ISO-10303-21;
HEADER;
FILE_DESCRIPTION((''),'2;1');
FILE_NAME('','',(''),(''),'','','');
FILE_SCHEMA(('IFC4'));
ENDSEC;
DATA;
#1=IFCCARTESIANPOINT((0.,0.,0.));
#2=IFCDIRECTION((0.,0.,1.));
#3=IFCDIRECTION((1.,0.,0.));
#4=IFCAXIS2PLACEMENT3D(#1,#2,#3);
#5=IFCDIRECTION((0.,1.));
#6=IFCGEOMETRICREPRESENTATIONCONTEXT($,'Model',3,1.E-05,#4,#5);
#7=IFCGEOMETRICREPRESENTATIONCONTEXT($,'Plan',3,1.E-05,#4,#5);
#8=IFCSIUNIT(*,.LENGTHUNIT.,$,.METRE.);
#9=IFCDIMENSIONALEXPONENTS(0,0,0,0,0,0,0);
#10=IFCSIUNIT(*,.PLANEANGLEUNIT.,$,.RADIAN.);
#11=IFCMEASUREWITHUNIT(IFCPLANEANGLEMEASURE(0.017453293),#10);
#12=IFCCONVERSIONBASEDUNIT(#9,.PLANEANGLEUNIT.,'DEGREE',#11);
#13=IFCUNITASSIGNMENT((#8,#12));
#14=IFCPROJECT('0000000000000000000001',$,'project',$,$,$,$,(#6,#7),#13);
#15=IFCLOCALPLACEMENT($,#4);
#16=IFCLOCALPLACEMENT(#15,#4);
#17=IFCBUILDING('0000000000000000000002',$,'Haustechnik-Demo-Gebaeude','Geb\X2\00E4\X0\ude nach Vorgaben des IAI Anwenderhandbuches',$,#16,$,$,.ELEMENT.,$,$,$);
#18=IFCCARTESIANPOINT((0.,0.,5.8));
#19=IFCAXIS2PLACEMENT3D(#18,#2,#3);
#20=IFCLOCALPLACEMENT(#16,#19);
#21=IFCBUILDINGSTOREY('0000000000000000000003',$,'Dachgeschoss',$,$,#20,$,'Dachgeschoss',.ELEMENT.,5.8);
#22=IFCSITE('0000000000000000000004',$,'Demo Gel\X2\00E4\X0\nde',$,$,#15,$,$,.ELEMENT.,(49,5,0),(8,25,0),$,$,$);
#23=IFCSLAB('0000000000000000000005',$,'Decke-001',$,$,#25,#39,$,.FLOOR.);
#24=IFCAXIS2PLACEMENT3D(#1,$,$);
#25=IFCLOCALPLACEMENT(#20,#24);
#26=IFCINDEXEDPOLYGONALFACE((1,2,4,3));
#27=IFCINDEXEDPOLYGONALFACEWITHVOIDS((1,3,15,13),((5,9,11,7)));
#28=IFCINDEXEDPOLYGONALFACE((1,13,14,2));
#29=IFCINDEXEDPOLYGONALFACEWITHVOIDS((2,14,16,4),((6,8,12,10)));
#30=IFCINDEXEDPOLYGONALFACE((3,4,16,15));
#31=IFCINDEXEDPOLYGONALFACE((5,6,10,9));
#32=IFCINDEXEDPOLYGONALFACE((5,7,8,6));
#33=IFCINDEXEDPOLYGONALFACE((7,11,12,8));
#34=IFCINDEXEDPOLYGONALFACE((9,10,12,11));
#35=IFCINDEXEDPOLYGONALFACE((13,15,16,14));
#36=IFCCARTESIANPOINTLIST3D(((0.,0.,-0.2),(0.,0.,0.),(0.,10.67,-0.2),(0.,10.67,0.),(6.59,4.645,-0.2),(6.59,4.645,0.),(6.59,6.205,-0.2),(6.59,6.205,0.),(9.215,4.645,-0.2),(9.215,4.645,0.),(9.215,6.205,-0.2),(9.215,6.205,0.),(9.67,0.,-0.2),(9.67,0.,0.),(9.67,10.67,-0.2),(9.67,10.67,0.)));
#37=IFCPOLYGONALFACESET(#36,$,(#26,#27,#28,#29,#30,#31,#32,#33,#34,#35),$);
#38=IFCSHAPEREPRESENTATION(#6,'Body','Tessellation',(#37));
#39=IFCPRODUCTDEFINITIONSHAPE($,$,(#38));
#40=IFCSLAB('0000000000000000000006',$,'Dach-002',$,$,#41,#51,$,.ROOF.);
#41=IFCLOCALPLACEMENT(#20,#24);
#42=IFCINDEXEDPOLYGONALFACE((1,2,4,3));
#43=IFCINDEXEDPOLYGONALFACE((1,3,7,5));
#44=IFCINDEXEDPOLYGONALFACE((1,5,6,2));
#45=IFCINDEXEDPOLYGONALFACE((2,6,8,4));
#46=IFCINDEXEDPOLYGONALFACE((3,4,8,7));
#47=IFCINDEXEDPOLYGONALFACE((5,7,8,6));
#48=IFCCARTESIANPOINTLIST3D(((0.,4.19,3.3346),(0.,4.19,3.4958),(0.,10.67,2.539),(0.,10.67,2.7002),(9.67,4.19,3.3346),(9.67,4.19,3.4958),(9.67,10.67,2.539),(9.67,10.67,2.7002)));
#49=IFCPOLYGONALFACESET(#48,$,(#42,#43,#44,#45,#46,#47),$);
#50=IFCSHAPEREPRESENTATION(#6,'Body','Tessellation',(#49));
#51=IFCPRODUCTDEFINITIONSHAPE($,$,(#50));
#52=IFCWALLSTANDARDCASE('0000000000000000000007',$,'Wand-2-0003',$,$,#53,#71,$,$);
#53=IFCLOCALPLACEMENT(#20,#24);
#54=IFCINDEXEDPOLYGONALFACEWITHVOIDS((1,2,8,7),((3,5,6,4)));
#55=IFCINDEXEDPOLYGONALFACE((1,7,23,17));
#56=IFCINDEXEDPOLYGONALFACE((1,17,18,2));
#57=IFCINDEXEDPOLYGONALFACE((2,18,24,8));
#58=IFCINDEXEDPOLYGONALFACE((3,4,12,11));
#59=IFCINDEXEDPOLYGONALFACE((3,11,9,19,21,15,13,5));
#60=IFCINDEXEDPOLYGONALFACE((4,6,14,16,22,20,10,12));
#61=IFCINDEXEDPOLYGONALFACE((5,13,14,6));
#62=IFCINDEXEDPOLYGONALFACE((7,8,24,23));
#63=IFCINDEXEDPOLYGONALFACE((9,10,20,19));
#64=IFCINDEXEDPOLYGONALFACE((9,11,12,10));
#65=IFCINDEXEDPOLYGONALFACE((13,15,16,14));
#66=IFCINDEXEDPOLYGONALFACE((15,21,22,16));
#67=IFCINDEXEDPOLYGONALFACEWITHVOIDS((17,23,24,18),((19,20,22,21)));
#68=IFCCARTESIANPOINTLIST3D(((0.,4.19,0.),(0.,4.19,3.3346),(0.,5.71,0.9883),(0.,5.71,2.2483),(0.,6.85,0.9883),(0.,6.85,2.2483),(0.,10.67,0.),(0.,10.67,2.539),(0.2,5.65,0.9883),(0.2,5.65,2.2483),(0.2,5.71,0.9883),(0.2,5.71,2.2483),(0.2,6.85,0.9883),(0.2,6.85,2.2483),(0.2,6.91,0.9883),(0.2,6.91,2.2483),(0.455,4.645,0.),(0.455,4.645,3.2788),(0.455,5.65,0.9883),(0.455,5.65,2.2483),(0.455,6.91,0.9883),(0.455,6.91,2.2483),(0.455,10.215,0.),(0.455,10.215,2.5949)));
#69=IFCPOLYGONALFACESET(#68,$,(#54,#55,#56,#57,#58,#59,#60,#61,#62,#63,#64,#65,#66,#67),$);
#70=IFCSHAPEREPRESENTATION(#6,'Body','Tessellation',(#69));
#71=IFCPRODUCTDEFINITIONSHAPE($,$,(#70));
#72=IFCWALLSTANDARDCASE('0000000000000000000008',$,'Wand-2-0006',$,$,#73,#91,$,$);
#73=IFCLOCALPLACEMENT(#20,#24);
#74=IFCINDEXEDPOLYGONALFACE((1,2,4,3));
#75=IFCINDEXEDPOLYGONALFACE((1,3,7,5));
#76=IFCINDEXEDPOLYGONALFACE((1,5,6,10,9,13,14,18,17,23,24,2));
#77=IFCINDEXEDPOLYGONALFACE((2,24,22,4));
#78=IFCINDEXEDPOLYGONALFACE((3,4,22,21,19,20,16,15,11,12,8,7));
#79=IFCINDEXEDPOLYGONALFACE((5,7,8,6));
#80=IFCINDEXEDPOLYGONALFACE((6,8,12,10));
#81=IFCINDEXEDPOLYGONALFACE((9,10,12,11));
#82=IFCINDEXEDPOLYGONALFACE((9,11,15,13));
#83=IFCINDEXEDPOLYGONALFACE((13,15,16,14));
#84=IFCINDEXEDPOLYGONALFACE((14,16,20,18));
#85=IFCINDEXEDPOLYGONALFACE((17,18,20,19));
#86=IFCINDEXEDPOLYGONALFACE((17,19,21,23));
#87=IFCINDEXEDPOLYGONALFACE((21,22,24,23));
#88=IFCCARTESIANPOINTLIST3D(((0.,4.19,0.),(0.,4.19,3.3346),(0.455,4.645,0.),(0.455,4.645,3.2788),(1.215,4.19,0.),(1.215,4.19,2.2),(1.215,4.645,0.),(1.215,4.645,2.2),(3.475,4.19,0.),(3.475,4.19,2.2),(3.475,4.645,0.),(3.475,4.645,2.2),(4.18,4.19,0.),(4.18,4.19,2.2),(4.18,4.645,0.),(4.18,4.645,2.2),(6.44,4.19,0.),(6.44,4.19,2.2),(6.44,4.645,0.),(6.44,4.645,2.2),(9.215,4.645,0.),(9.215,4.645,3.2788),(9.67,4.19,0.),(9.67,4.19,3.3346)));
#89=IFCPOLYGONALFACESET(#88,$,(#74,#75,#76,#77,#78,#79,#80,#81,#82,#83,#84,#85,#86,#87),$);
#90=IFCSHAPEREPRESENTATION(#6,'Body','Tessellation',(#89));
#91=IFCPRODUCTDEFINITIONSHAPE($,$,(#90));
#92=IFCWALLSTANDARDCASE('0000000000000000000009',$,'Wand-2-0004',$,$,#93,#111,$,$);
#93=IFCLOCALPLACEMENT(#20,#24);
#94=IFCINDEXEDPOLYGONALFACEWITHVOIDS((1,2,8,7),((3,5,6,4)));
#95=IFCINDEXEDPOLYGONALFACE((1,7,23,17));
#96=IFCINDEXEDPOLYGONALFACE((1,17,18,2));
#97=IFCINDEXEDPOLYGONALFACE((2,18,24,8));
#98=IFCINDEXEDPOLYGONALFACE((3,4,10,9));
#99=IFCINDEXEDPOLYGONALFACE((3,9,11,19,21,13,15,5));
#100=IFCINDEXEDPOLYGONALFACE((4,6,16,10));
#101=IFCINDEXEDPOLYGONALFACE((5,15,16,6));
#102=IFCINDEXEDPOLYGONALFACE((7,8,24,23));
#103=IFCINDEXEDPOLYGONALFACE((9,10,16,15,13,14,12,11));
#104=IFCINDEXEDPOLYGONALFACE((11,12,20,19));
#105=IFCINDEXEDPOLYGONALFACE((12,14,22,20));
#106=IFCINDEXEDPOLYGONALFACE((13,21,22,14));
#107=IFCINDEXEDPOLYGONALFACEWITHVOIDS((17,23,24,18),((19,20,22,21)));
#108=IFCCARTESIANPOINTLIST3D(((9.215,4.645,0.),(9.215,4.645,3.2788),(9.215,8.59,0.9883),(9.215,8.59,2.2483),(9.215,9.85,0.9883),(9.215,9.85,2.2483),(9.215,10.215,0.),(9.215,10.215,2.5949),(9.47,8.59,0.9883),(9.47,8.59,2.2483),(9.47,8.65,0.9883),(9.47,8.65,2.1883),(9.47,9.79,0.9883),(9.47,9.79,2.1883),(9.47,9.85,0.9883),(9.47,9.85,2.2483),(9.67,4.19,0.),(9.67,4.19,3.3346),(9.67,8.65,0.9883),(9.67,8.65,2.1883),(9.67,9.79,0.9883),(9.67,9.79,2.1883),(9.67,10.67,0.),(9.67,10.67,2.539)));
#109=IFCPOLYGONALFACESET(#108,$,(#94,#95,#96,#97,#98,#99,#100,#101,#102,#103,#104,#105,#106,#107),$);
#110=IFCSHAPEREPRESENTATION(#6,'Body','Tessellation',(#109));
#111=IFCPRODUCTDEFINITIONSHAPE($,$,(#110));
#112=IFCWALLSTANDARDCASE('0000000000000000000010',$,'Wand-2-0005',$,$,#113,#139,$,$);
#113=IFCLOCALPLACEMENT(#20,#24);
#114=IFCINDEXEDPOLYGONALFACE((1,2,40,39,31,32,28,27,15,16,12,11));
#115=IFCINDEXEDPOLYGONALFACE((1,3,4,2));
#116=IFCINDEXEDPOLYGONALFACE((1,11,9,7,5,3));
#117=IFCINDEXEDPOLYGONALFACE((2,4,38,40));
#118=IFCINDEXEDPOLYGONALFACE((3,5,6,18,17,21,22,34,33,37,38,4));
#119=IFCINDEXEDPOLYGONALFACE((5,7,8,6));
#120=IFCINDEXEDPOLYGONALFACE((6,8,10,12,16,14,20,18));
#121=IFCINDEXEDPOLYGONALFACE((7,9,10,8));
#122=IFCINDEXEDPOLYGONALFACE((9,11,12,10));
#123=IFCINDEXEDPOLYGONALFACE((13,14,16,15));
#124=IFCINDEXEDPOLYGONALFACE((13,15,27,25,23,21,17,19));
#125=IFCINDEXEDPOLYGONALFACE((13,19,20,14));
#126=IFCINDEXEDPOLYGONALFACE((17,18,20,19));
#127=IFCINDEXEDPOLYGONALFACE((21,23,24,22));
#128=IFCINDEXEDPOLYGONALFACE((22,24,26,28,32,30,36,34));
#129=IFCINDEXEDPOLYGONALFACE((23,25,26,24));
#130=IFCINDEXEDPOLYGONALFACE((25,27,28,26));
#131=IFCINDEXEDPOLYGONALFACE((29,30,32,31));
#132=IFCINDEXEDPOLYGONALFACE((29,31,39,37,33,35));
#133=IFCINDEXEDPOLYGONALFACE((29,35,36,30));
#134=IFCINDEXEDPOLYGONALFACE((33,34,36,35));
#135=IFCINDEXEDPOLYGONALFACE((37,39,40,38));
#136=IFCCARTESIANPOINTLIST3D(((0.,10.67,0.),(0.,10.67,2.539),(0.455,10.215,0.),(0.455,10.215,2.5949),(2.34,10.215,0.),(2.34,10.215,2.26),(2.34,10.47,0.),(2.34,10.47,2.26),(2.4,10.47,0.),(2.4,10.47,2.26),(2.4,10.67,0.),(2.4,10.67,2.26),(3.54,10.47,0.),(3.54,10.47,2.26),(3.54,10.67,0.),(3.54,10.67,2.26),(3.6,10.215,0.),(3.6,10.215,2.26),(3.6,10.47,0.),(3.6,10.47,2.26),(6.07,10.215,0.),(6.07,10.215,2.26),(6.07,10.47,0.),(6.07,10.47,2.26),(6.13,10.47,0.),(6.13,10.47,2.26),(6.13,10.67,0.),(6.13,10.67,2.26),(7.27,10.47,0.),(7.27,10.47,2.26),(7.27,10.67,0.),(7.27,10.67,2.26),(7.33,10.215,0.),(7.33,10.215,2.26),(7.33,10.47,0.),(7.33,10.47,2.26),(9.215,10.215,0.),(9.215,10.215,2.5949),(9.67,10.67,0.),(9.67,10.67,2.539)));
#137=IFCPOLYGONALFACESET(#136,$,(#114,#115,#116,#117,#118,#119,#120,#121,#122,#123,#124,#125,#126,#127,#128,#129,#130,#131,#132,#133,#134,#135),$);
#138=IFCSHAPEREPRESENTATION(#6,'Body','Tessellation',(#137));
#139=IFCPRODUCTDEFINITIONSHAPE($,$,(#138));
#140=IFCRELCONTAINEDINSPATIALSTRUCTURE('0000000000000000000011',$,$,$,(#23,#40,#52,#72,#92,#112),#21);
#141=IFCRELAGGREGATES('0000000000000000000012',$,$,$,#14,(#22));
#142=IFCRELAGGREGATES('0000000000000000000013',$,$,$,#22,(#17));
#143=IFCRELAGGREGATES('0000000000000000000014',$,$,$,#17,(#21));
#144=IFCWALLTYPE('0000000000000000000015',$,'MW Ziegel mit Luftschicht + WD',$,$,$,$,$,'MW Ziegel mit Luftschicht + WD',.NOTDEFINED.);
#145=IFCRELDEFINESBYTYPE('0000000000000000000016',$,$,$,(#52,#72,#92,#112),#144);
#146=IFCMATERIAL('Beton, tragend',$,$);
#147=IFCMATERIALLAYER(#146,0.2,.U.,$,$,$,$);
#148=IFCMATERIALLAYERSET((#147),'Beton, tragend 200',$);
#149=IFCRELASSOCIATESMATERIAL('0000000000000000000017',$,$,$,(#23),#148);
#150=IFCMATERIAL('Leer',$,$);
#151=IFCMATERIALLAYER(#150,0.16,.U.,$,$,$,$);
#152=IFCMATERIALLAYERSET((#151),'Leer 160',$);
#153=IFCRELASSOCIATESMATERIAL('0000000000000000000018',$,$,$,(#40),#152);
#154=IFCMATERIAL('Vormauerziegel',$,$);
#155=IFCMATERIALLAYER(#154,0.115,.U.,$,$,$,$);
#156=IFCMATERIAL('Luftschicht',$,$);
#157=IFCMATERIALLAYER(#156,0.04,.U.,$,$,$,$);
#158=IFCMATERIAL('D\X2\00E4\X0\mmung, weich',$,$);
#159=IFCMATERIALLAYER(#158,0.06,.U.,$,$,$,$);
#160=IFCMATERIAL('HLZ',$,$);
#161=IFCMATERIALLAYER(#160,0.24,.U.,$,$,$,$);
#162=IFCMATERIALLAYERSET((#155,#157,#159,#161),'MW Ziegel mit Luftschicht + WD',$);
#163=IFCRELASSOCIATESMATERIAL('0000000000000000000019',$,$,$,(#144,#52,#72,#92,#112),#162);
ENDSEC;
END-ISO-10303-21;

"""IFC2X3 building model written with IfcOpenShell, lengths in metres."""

from ifc_helpers import new_model, entity, si_unit, converted_unit, direction, frame, frame_2d, origin_with_axes, place, context, project, spatial, polyline, rectangle, outline, extrude, clip, halfspace, bounded_halfspace, material, layer, layer_set, layer_usage, type_object, element, save


model = new_model("IFC2X3")

# Units and contexts
model_context = context("Model", 3, precision=1e-05, world=origin_with_axes(), true_north=direction((0.0, 1.0)))
plan_context = context("Plan", 3, precision=1e-05, world=origin_with_axes(), true_north=direction((0.0, 1.0)))
ifc_project = project(units=[si_unit("LENGTHUNIT", "METRE"), converted_unit("PLANEANGLEUNIT", "DEGREE", entity("IfcPlaneAngleMeasure", 0.017453293), si_unit("PLANEANGLEUNIT", "RADIAN"), dimensions=[0, 0, 0, 0, 0, 0, 0])], contexts=[model_context, plan_context])

# Site, building, storey
site_placement = place(None, origin_with_axes())
site = spatial("IfcSite", under=ifc_project, at=site_placement, Name="Demo Gelände", CompositionType="ELEMENT", RefLatitude=(49, 5, 0), RefLongitude=(8, 25, 0))
building_placement = place(site_placement, origin_with_axes())
building = spatial("IfcBuilding", under=site, at=building_placement, Name="Haustechnik-Demo-Gebaeude", Description="Gebäude nach Vorgaben des IAI Anwenderhandbuches", CompositionType="ELEMENT")
storey_placement = place(building_placement, frame((0.0, 0.0, 5.8), z_axis=(0.0, 0.0, 1.0), x_axis=(1.0, 0.0, 0.0)))
storey = spatial("IfcBuildingStorey", under=building, at=storey_placement, Name="Dachgeschoss", LongName="Dachgeschoss", CompositionType="ELEMENT", Elevation=5.8)

# Slab, opening
ifc_material_1 = material(Name="Beton, tragend")
ifc_layer_1 = layer(ifc_material_1, 0.2, ventilated="UNKNOWN")
ifc_layer_set_1 = layer_set([ifc_layer_1], Name="Beton, tragend 200")
ifc_layer_usage_1 = layer_usage(ifc_layer_set_1, "AXIS3", "NEGATIVE", 0.2)
slab_1_placement = place(storey_placement, frame((9.67, 10.67, -0.2), z_axis=(0.0, 0.0, 1.0), x_axis=(-1.0, 0.0, 0.0)))
slab_1 = element("IfcSlab", 1, at=slab_1_placement, inside=storey, material=ifc_layer_usage_1, Name="Decke-001", PredefinedType="FLOOR", context=model_context, shape_type="SweptSolid", body=[
    extrude(outline(polyline([(0.0, 0.0), (9.67, 0.0), (9.67, 6.48), (9.67, 10.67), (0.0, 10.67), (0.0, 6.48), (0.0, 0.0)])), origin_with_axes(), (0.0, 0.0, 1.0), 0.2),
])
opening_1_placement = place(slab_1_placement, origin_with_axes())
element("IfcOpeningElement", 2, at=opening_1_placement, cuts=slab_1, context=model_context, shape_type="SweptSolid", body=[
    extrude(outline(polyline([(0.455, 6.025), (3.08, 6.025), (3.08, 4.465), (0.455, 4.465), (0.455, 6.025)])), origin_with_axes(), (0.0, 0.0, 1.0), 0.2),
])

# Slab
ifc_material_2 = material(Name="Leer")
ifc_layer_2 = layer(ifc_material_2, 0.16, ventilated="UNKNOWN")
ifc_layer_set_2 = layer_set([ifc_layer_2], Name="Leer 160")
ifc_layer_usage_2 = layer_usage(ifc_layer_set_2, "AXIS3", "NEGATIVE", 0.16)
slab_2_placement = place(storey_placement, frame((9.67, 10.67, 2.539), z_axis=(0.0, 0.121869, 0.992546), x_axis=(-1.0, 0.0, 0.0)))
element("IfcSlab", 3, at=slab_2_placement, inside=storey, material=ifc_layer_usage_2, Name="Dach-002", PredefinedType="ROOF", context=model_context, shape_type="SweptSolid", body=[
    extrude(outline(polyline([(9.67, 0.0), (9.67, 6.5287), (0.0, 6.5287), (0.0, 0.0), (9.67, 0.0)])), origin_with_axes(), (0.0, 0.121869, 0.992546), 0.1612),
])

# Wall, opening
ifc_material_3 = material(Name="Vormauerziegel")
ifc_layer_3 = layer(ifc_material_3, 0.115, ventilated="UNKNOWN")
ifc_material_4 = material(Name="Luftschicht")
ifc_layer_4 = layer(ifc_material_4, 0.04, ventilated="UNKNOWN")
ifc_material_5 = material(Name="Dämmung, weich")
ifc_layer_5 = layer(ifc_material_5, 0.06, ventilated="UNKNOWN")
ifc_material_6 = material(Name="HLZ")
ifc_layer_6 = layer(ifc_material_6, 0.24, ventilated="UNKNOWN")
ifc_layer_set_3 = layer_set([ifc_layer_3, ifc_layer_4, ifc_layer_5, ifc_layer_6], Name="MW Ziegel mit Luftschicht + WD")
ifc_layer_usage_3 = layer_usage(ifc_layer_set_3, "AXIS2", "POSITIVE", 0.0)
wall_type_1 = type_object("IfcWallType", Name="MW Ziegel mit Luftschicht + WD", ElementType="MW Ziegel mit Luftschicht + WD", PredefinedType="NOTDEFINED", material=ifc_layer_set_3)
wall_1_placement = place(storey_placement, frame((0.0, 10.67, 0.0), z_axis=(0.0, 0.0, 1.0), x_axis=(0.0, -1.0, 0.0)))
wall_1 = element("IfcWallStandardCase", 4, at=wall_1_placement, inside=storey, type_object=wall_type_1, material=ifc_layer_usage_3, Name="Wand-2-0003", context=model_context, shape_type="Clipping", body=[
    clip(clip(extrude(outline(polyline([(0.0, 0.0), (6.48, 0.0), (6.025, 0.455), (0.455, 0.455), (0.0, 0.0)])), origin_with_axes(), (0.0, 0.0, 1.0), 4.0), halfspace(frame((-0.3071, 0.0, 2.5013), z_axis=(-0.121869, 0.0, 0.992546), x_axis=(0.0, 1.0, 0.0)), False)), halfspace(frame((-0.3266, 0.0, 2.6596), z_axis=(-0.121869, 0.0, 0.992546), x_axis=(0.0, 1.0, 0.0)), False)),
])
opening_2_placement = place(wall_1_placement, frame((4.39, 0.0, 0.9883), z_axis=(0.0, 0.0, 1.0), x_axis=(1.0, 0.0, 0.0)))
element("IfcOpeningElement", 5, at=opening_2_placement, cuts=wall_1, ObjectType="Opening", context=model_context, shape_type="SweptSolid", body=[
    extrude(outline(polyline([(-0.57, 0.0), (0.57, 0.0), (0.57, 0.2), (0.63, 0.2), (0.63, 0.455), (-0.63, 0.455), (-0.63, 0.2), (-0.57, 0.2), (-0.57, 0.0)])), origin_with_axes(), (0.0, 0.0, 1.0), 1.26),
])

# Wall, openings
ifc_layer_usage_4 = layer_usage(ifc_layer_set_3, "AXIS2", "POSITIVE", 0.0)
wall_2_placement = place(storey_placement, frame((0.0, 4.19, 0.0), z_axis=(0.0, 0.0, 1.0), x_axis=(1.0, 0.0, 0.0)))
wall_2 = element("IfcWallStandardCase", 6, at=wall_2_placement, inside=storey, type_object=wall_type_1, material=ifc_layer_usage_4, Name="Wand-2-0006", context=model_context, shape_type="Clipping", body=[
    clip(clip(extrude(outline(polyline([(0.0, 0.0), (9.67, 0.0), (9.215, 0.455), (0.455, 0.455), (0.0, 0.0)])), origin_with_axes(), (0.0, 0.0, 1.0), 4.0), halfspace(frame((0.0, 0.4034, 3.2851), z_axis=(0.0, 0.121869, 0.992546), x_axis=(0.0, 0.992546, -0.121869)), False)), bounded_halfspace(frame((0.0, 0.4228, 3.4434), z_axis=(0.0, 0.121869, 0.992546), x_axis=(0.0, 0.992546, -0.121869)), False, origin_with_axes(), polyline([(9.67, -0.2275), (9.67, 0.6825), (0.0, 0.6825), (0.0, -0.2275), (9.67, -0.2275)]))),
])
opening_3_placement = place(wall_2_placement, frame((2.345, 0.0, 0.0), z_axis=(0.0, 0.0, 1.0), x_axis=(1.0, 0.0, 0.0)))
element("IfcOpeningElement", 7, at=opening_3_placement, cuts=wall_2, ObjectType="Opening", context=model_context, shape_type="SweptSolid", body=[
    extrude(rectangle(XDim=2.26, YDim=2.2, at=frame_2d((0.0, 1.1), x_axis=(-1.0, 0.0))), frame((0.0, 0.0, 0.0), z_axis=(0.0, 1.0, 0.0), x_axis=(-1.0, 0.0, 0.0)), (0.0, 0.0, 1.0), 0.455),
])
opening_4_placement = place(wall_2_placement, frame((5.31, 0.0, 0.0), z_axis=(0.0, 0.0, 1.0), x_axis=(1.0, 0.0, 0.0)))
element("IfcOpeningElement", 8, at=opening_4_placement, cuts=wall_2, ObjectType="Opening", context=model_context, shape_type="SweptSolid", body=[
    extrude(rectangle(XDim=2.26, YDim=2.2, at=frame_2d((0.0, 1.1), x_axis=(1.0, 0.0))), frame((0.0, 0.0, 0.0), z_axis=(0.0, 1.0, 0.0), x_axis=(-1.0, 0.0, 0.0)), (0.0, 0.0, 1.0), 0.455),
])

# Wall, opening
ifc_layer_usage_5 = layer_usage(ifc_layer_set_3, "AXIS2", "POSITIVE", 0.0)
wall_3_placement = place(storey_placement, frame((9.67, 4.19, 0.0), z_axis=(0.0, 0.0, 1.0), x_axis=(0.0, 1.0, 0.0)))
wall_3 = element("IfcWallStandardCase", 9, at=wall_3_placement, inside=storey, type_object=wall_type_1, material=ifc_layer_usage_5, Name="Wand-2-0004", context=model_context, shape_type="Clipping", body=[
    clip(clip(extrude(outline(polyline([(0.0, 0.0), (6.48, 0.0), (6.025, 0.455), (0.455, 0.455), (0.0, 0.0)])), origin_with_axes(), (0.0, 0.0, 1.0), 4.0), halfspace(frame((0.4034, 0.0, 3.2851), z_axis=(0.121869, 0.0, 0.992546), x_axis=(0.0, 1.0, 0.0)), False)), halfspace(frame((0.4228, 0.0, 3.4434), z_axis=(0.121869, 0.0, 0.992546), x_axis=(0.0, 1.0, 0.0)), False)),
])
opening_5_placement = place(wall_3_placement, frame((5.03, 0.0, 0.9883), z_axis=(0.0, 0.0, 1.0), x_axis=(1.0, 0.0, 0.0)))
element("IfcOpeningElement", 10, at=opening_5_placement, cuts=wall_3, ObjectType="Opening", context=model_context, shape_type="SweptSolid", body=[
    extrude(rectangle(XDim=1.26, YDim=1.26, at=frame_2d((0.0, 0.63), x_axis=(1.0, 0.0))), frame((0.0, 0.2, 0.0), z_axis=(0.0, 1.0, 0.0), x_axis=(-1.0, 0.0, 0.0)), (0.0, 0.0, 1.0), 0.255),
    extrude(rectangle(XDim=1.14, YDim=1.2, at=frame_2d((0.0, 0.6), x_axis=(1.0, 0.0))), frame((0.0, 0.0, 0.0), z_axis=(0.0, 1.0, 0.0), x_axis=(-1.0, 0.0, 0.0)), (0.0, 0.0, 1.0), 0.2),
])

# Wall, openings
ifc_layer_usage_6 = layer_usage(ifc_layer_set_3, "AXIS2", "NEGATIVE", 0.0)
wall_4_placement = place(storey_placement, frame((0.0, 10.67, 0.0), z_axis=(0.0, 0.0, 1.0), x_axis=(1.0, 0.0, 0.0)))
wall_4 = element("IfcWallStandardCase", 11, at=wall_4_placement, inside=storey, type_object=wall_type_1, material=ifc_layer_usage_6, Name="Wand-2-0005", context=model_context, shape_type="Clipping", body=[
    clip(clip(extrude(outline(polyline([(0.455, -0.455), (9.215, -0.455), (9.67, 0.0), (0.0, 0.0), (0.455, -0.455)])), origin_with_axes(), (0.0, 0.0, 1.0), 4.0), halfspace(frame((0.0, 0.3071, 2.5013), z_axis=(0.0, 0.121869, 0.992546), x_axis=(0.0, 0.992546, -0.121869)), False)), halfspace(frame((0.0, 0.3266, 2.6596), z_axis=(0.0, 0.121869, 0.992546), x_axis=(0.0, 0.992546, -0.121869)), False)),
])
opening_6_placement = place(wall_4_placement, frame((2.97, -0.455, 0.0), z_axis=(0.0, 0.0, 1.0), x_axis=(1.0, 0.0, 0.0)))
element("IfcOpeningElement", 12, at=opening_6_placement, cuts=wall_4, ObjectType="Opening", context=model_context, shape_type="SweptSolid", body=[
    extrude(outline(polyline([(-0.63, 0.0), (0.63, 0.0), (0.63, 0.255), (0.57, 0.255), (0.57, 0.455), (-0.57, 0.455), (-0.57, 0.255), (-0.63, 0.255), (-0.63, 0.0)])), origin_with_axes(), (0.0, 0.0, 1.0), 2.26),
])
opening_7_placement = place(wall_4_placement, frame((6.7, -0.455, 0.0), z_axis=(0.0, 0.0, 1.0), x_axis=(1.0, 0.0, 0.0)))
element("IfcOpeningElement", 13, at=opening_7_placement, cuts=wall_4, ObjectType="Opening", context=model_context, shape_type="SweptSolid", body=[
    extrude(outline(polyline([(-0.63, 0.0), (0.63, 0.0), (0.63, 0.255), (0.57, 0.255), (0.57, 0.455), (-0.57, 0.455), (-0.57, 0.255), (-0.63, 0.255), (-0.63, 0.0)])), origin_with_axes(), (0.0, 0.0, 1.0), 2.26),
])

save(model, "model.ifc")
